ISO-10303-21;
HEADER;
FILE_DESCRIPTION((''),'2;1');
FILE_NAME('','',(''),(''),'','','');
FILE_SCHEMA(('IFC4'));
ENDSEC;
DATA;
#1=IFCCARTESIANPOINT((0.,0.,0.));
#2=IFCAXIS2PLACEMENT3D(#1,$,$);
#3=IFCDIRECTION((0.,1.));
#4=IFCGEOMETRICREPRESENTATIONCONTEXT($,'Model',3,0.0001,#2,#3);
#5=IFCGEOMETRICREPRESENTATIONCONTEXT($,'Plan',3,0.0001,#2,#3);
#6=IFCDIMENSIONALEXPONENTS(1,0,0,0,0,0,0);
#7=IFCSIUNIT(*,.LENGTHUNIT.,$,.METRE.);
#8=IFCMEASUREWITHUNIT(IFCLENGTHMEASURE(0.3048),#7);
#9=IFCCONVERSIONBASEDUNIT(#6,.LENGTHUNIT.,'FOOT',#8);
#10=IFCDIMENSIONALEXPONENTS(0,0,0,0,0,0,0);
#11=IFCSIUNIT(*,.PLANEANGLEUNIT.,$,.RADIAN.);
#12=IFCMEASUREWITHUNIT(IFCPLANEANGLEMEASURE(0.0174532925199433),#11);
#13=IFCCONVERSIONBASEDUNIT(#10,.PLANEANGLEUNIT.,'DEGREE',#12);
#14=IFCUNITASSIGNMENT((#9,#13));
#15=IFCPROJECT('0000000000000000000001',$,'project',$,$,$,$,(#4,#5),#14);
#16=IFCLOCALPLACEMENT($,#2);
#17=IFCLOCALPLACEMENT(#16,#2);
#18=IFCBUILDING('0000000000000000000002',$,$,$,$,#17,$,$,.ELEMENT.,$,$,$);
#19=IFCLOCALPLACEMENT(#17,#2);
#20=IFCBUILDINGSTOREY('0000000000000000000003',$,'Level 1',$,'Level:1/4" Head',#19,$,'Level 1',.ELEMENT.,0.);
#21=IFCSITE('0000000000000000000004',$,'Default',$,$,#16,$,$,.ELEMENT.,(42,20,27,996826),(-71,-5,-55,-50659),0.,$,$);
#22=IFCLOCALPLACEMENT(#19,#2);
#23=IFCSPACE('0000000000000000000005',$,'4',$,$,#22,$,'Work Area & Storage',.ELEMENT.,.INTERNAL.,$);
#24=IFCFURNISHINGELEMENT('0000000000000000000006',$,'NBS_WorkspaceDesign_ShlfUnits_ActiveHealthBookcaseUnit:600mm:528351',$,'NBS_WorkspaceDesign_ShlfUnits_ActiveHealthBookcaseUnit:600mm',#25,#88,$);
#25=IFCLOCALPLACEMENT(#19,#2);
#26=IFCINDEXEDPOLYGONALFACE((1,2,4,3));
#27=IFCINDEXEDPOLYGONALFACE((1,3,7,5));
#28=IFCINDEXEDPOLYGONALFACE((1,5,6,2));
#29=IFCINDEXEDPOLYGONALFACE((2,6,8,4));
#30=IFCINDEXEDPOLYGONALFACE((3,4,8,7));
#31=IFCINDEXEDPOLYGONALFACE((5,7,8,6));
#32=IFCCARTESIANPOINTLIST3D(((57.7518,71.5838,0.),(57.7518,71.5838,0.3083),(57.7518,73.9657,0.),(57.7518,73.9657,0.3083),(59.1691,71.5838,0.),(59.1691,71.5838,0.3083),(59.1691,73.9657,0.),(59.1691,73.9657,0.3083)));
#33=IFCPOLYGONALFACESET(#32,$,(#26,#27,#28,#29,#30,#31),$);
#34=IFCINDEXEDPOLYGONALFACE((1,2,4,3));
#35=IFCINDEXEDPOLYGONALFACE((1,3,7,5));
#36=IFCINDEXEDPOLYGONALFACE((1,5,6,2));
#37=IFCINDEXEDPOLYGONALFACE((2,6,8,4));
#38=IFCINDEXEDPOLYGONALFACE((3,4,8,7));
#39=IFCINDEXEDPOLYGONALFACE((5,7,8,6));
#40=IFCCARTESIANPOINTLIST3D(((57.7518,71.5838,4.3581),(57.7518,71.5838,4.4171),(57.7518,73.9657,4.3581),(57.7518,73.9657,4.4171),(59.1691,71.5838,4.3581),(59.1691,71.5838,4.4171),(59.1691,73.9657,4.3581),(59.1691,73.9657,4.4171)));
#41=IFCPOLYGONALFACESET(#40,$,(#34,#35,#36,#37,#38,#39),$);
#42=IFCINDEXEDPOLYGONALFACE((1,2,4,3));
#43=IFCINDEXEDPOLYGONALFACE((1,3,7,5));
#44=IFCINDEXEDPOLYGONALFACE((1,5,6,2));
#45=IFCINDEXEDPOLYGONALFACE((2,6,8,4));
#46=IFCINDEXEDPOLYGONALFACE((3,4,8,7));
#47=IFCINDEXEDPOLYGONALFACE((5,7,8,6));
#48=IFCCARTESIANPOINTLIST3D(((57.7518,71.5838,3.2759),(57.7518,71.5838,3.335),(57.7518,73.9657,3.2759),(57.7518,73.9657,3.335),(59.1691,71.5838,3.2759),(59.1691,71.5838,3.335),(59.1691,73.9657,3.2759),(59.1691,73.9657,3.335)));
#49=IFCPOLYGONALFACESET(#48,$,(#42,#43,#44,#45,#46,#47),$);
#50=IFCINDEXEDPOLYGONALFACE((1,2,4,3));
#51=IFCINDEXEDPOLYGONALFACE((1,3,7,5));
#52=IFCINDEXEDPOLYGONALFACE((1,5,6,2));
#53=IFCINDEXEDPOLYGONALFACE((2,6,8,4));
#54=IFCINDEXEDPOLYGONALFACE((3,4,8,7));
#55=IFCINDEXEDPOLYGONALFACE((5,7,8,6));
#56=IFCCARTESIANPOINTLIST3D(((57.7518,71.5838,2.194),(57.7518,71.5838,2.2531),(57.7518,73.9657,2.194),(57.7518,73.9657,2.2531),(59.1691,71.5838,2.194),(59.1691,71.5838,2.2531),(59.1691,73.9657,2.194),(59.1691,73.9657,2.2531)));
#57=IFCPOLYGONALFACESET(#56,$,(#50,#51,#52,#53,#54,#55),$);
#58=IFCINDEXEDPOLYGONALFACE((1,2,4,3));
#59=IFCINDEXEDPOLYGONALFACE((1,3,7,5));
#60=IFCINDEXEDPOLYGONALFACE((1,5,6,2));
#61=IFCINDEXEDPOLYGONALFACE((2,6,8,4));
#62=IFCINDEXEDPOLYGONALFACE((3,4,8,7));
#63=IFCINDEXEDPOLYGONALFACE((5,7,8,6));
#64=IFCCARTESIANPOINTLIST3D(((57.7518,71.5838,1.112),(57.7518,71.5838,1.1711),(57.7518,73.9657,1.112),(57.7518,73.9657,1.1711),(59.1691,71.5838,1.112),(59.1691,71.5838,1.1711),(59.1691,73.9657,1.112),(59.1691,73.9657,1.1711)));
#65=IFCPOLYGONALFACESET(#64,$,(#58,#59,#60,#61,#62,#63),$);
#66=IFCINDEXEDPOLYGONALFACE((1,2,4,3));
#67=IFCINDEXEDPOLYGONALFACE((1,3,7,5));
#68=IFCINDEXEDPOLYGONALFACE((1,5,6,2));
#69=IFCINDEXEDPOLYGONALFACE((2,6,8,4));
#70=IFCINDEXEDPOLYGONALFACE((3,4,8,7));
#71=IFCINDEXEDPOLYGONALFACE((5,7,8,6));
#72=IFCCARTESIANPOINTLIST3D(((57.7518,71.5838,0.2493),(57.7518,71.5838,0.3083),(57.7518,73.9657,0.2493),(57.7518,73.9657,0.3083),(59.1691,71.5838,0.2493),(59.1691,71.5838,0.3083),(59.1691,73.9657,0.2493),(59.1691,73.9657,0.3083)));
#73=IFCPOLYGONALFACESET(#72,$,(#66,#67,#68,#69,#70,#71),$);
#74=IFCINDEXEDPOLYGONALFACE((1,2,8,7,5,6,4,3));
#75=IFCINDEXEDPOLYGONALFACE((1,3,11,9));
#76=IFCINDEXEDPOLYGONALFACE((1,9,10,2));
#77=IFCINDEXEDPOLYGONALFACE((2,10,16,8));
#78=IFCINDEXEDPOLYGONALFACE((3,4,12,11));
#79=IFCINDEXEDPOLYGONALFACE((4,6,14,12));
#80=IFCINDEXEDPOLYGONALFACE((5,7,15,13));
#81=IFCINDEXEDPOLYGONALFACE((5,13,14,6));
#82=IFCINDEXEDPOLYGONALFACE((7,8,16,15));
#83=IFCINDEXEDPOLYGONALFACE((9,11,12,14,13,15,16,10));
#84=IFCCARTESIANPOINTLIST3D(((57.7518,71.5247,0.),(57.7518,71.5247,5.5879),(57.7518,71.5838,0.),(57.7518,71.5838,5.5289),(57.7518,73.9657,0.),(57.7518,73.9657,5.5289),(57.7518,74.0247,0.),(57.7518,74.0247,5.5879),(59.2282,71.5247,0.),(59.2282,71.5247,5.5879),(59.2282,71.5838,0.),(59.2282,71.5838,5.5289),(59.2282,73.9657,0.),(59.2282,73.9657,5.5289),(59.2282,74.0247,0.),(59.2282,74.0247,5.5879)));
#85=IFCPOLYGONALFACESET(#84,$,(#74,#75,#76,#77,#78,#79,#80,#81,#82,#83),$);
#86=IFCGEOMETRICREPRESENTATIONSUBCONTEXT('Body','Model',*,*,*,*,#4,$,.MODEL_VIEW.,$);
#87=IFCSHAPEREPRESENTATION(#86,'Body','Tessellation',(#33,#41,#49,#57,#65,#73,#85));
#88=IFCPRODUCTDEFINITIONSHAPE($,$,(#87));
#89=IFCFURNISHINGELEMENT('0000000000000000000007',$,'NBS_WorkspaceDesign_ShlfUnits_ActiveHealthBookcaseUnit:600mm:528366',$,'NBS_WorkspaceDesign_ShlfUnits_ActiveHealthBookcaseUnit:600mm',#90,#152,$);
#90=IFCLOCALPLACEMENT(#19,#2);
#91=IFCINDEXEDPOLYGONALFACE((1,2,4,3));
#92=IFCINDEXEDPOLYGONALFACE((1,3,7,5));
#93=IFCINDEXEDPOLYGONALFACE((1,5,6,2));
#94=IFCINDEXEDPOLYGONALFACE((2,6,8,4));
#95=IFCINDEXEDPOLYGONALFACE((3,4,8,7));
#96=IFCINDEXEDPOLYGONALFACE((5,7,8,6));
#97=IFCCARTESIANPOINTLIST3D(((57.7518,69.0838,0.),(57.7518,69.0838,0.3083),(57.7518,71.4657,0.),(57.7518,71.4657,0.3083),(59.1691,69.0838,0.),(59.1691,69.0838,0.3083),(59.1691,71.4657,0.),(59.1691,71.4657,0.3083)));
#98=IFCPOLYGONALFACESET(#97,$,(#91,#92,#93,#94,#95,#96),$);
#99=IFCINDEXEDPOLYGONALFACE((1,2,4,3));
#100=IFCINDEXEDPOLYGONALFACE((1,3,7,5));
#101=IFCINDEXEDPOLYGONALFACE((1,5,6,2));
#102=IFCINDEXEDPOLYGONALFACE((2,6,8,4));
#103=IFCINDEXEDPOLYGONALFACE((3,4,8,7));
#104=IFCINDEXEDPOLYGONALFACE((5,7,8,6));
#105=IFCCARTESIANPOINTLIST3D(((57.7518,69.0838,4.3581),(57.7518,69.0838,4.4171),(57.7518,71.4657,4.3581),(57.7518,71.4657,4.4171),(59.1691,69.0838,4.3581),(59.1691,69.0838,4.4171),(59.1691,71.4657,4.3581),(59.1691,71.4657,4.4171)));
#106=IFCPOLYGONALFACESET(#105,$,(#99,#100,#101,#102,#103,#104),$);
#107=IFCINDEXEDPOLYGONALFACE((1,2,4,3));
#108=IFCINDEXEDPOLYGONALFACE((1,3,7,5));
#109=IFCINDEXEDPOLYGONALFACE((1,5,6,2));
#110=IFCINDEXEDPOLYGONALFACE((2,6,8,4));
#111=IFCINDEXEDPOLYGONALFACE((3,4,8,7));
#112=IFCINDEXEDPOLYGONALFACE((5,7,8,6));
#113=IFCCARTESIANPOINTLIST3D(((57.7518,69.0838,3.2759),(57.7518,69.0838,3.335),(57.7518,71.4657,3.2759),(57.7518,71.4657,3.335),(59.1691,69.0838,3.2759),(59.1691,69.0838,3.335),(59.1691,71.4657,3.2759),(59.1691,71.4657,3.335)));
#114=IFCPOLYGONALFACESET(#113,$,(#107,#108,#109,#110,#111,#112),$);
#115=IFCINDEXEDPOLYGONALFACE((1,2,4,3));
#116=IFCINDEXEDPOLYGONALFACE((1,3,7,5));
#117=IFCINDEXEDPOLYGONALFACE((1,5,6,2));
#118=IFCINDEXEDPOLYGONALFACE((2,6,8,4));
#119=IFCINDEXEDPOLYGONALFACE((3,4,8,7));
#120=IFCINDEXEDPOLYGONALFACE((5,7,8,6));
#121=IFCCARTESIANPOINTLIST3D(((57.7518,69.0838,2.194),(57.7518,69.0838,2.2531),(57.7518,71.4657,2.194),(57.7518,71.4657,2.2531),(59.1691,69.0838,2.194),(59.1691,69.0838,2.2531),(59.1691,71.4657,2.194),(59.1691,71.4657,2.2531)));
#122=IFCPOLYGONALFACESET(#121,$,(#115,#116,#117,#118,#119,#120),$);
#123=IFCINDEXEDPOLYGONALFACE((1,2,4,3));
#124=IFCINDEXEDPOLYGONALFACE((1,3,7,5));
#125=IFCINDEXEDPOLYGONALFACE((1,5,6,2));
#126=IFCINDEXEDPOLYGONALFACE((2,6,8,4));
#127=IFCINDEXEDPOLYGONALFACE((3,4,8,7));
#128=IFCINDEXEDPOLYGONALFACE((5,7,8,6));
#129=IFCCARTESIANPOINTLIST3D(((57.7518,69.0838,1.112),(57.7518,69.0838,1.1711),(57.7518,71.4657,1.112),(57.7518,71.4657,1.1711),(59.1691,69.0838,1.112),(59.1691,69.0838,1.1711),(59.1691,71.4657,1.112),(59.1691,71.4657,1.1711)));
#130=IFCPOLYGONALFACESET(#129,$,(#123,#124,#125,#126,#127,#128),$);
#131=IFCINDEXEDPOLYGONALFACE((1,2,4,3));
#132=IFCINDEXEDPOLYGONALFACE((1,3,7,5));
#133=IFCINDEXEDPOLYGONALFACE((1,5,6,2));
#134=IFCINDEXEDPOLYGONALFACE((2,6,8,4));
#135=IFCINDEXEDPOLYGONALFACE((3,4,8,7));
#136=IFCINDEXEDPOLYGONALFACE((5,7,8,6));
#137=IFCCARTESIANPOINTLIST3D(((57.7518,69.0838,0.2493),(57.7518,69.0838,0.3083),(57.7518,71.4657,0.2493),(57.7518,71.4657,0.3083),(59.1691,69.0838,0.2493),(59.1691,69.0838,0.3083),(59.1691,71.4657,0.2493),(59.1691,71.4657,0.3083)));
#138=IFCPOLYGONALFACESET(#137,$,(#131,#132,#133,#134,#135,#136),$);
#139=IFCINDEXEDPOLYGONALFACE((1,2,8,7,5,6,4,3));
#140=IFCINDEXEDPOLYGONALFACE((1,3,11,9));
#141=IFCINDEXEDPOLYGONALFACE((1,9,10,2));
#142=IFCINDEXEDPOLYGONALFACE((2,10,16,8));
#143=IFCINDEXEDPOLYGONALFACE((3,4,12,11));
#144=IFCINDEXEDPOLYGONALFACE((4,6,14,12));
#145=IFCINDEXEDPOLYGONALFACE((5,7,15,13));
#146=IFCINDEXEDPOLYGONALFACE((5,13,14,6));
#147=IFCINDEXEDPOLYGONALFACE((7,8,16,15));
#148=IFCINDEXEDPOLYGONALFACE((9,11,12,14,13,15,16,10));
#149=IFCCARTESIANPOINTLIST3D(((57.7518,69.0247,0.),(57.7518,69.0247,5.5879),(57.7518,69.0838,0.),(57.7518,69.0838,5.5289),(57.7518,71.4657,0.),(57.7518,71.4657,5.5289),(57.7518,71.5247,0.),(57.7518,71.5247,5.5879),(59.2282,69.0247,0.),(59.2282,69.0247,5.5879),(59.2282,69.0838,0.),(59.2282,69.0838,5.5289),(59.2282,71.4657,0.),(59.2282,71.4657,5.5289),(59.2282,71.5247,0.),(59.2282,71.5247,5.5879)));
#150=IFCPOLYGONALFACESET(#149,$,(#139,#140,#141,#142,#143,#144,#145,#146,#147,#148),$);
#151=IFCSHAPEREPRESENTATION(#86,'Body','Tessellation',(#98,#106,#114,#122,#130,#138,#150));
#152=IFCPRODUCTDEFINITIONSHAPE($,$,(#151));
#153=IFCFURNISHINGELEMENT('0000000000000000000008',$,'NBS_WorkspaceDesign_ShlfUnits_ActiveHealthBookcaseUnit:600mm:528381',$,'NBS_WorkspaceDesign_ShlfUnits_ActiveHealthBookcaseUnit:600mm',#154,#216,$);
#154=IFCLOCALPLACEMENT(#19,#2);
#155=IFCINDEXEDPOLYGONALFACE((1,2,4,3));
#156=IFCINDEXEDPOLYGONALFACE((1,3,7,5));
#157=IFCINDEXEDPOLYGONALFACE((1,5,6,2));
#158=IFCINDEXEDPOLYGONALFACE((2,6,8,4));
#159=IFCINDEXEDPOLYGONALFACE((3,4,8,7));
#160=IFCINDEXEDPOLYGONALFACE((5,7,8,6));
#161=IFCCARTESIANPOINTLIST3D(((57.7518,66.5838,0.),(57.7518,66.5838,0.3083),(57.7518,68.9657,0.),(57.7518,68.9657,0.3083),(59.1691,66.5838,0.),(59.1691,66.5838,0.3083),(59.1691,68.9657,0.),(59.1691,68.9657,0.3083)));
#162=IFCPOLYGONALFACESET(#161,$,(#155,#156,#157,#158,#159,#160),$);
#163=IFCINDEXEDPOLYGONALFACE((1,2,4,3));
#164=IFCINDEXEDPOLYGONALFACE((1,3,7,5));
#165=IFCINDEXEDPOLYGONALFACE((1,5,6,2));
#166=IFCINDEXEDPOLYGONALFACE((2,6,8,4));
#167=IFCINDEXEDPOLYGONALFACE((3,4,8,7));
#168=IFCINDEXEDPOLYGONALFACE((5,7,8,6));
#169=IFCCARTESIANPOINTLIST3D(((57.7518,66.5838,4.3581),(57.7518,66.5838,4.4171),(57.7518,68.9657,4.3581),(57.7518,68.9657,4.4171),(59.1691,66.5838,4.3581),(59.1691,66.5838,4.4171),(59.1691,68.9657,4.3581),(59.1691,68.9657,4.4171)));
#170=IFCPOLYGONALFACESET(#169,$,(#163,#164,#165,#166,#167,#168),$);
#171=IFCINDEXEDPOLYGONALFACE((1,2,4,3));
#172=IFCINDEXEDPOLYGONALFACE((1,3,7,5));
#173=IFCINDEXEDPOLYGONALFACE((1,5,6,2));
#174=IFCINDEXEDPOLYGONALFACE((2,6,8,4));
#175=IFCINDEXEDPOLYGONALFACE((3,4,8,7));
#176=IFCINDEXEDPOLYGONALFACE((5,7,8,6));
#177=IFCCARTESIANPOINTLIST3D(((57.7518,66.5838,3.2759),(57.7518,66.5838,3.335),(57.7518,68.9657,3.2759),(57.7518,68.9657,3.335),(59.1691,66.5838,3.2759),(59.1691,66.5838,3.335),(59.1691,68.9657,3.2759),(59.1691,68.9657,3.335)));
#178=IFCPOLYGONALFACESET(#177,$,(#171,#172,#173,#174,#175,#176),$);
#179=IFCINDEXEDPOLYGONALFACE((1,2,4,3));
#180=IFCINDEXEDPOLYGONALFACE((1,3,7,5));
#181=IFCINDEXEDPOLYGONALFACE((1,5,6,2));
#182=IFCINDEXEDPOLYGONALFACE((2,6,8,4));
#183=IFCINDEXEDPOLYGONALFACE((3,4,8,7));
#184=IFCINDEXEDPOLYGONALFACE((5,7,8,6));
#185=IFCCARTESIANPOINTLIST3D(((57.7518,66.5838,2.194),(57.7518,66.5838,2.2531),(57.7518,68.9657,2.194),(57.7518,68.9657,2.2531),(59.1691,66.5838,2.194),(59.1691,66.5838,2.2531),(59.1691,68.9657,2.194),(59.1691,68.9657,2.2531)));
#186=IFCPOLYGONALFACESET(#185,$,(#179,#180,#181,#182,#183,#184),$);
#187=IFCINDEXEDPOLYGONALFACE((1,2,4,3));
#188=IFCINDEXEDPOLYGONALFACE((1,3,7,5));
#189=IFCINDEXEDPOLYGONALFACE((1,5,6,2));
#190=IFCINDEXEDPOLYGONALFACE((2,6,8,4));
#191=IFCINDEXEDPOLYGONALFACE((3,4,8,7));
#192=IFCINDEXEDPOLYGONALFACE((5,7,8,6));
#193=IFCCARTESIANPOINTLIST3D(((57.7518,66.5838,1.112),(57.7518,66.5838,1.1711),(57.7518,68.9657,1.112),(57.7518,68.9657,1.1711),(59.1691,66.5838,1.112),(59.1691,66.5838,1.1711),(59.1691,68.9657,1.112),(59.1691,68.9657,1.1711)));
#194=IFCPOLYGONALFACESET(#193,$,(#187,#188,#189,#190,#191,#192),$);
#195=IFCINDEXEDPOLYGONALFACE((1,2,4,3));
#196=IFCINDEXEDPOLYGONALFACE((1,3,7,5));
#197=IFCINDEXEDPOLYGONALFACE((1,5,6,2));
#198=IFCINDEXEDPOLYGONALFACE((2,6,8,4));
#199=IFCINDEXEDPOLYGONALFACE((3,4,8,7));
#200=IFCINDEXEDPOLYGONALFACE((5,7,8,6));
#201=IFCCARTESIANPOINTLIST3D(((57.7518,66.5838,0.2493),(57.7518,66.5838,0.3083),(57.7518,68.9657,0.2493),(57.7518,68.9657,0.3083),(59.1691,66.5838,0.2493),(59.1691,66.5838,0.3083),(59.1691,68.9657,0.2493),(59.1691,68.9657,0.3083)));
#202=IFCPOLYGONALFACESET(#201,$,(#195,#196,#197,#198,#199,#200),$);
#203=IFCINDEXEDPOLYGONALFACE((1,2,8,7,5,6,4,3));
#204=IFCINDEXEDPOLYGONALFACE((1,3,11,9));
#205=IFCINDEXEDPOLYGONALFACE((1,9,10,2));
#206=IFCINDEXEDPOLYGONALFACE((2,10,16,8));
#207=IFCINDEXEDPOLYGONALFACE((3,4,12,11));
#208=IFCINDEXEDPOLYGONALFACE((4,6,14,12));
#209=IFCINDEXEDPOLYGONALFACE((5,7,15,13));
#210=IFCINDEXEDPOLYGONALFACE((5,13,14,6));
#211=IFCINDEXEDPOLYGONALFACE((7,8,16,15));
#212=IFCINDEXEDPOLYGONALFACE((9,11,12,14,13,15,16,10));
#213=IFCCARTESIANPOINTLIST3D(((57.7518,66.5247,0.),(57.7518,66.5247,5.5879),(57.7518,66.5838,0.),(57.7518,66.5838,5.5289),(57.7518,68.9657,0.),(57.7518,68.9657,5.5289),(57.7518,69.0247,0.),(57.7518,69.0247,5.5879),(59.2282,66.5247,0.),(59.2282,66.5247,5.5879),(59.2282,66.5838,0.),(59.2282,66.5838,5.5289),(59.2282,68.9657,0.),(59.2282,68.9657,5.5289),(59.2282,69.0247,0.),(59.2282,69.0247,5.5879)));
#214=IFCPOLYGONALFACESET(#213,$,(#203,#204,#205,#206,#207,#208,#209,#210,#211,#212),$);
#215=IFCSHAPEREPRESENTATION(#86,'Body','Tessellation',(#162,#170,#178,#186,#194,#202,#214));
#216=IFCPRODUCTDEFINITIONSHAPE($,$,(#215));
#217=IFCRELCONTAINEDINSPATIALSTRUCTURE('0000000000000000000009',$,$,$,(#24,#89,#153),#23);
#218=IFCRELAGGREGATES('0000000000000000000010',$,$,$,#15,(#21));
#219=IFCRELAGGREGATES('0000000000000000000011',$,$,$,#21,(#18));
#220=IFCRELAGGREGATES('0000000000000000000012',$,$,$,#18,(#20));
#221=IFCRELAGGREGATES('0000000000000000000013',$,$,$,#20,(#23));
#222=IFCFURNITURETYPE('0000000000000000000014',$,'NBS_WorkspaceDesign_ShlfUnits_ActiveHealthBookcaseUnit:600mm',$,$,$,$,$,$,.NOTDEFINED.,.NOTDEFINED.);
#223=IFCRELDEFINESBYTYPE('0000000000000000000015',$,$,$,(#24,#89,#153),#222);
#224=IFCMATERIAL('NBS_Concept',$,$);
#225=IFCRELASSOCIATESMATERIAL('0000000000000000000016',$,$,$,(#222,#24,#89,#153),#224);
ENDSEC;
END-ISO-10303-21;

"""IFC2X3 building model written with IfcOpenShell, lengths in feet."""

from ifc_helpers import new_model, entity, si_unit, converted_unit, direction, frame, frame_2d, origin, place, context, subcontext, project, spatial, polyline, rectangle, outline, extrude, source, transform, mapped, material, type_object, type_shapes, element, save


model = new_model("IFC2X3")

# Units and contexts
model_context = context("Model", 3, precision=0.0001, world=origin(), true_north=direction((0.0, 1.0)))
plan_context = context("Plan", 3, precision=0.0001, world=origin(), true_north=direction((0.0, 1.0)))
body_context = subcontext(model_context, "Body", "Model", "MODEL_VIEW")
ifc_project = project(units=[converted_unit("LENGTHUNIT", "FOOT", entity("IfcLengthMeasure", 0.3048), si_unit("LENGTHUNIT", "METRE"), dimensions=[1, 0, 0, 0, 0, 0, 0]), converted_unit("PLANEANGLEUNIT", "DEGREE", entity("IfcPlaneAngleMeasure", 0.0174532925199433), si_unit("PLANEANGLEUNIT", "RADIAN"), dimensions=[0, 0, 0, 0, 0, 0, 0])], contexts=[model_context, plan_context])

# Site, building, storey
site_placement = place(None, origin())
site = spatial("IfcSite", under=ifc_project, at=site_placement, Name="Default", CompositionType="ELEMENT", RefLatitude=(42, 20, 27, 996826), RefLongitude=(-71, -5, -55, -50659), RefElevation=0.0)
building_placement = place(site_placement, origin())
building = spatial("IfcBuilding", under=site, at=building_placement, CompositionType="ELEMENT")
storey_placement = place(building_placement, origin())
storey = spatial("IfcBuildingStorey", under=building, at=storey_placement, Name="Level 1", ObjectType="Level:1/4\" Head", LongName="Level 1", CompositionType="ELEMENT", Elevation=0.0)

# Shared definitions
space_1_placement = place(storey_placement, origin())
space_1 = spatial("IfcSpace", under=storey, at=space_1_placement, Name="4", LongName="Work Area & Storage", CompositionType="ELEMENT", InteriorOrExteriorSpace="INTERNAL")

# Furnishing elements
ifc_material_1 = material(Name="NBS_Concept")
furniture_type_1 = type_object("IfcFurnitureType", Name="NBS_WorkspaceDesign_ShlfUnits_ActiveHealthBookcaseUnit:600mm", AssemblyPlace="NOTDEFINED", material=ifc_material_1)
shared_shape_1 = source(origin(), body_context, "Body", "SweptSolid", [
    extrude(rectangle(XDim=1.4173, YDim=2.3819, at=frame_2d((0.0, 0.0), x_axis=(1.0, 0.0))), frame((0.0, -0.7677, 0.0), z_axis=(0.0, 0.0, 1.0), x_axis=(0.0, 1.0, 0.0)), (0.0, 0.0, 1.0), 0.3083),
    extrude(rectangle(XDim=1.4173, YDim=2.3819, at=frame_2d((0.0, 0.0), x_axis=(1.0, 0.0))), frame((0.0, -0.7677, 4.3581), z_axis=(0.0, 0.0, 1.0), x_axis=(0.0, 1.0, 0.0)), (0.0, 0.0, 1.0), 0.0591),
    extrude(rectangle(XDim=1.4173, YDim=2.3819, at=frame_2d((0.0, 0.0), x_axis=(1.0, 0.0))), frame((0.0, -0.7677, 3.2759), z_axis=(0.0, 0.0, 1.0), x_axis=(0.0, 1.0, 0.0)), (0.0, 0.0, 1.0), 0.0591),
    extrude(rectangle(XDim=1.4173, YDim=2.3819, at=frame_2d((0.0, 0.0), x_axis=(1.0, 0.0))), frame((0.0, -0.7677, 2.194), z_axis=(0.0, 0.0, 1.0), x_axis=(0.0, 1.0, 0.0)), (0.0, 0.0, 1.0), 0.0591),
    extrude(rectangle(XDim=1.4173, YDim=2.3819, at=frame_2d((0.0, 0.0), x_axis=(1.0, 0.0))), frame((0.0, -0.7677, 1.112), z_axis=(0.0, 0.0, 1.0), x_axis=(0.0, 1.0, 0.0)), (0.0, 0.0, 1.0), 0.0591),
    extrude(rectangle(XDim=1.4173, YDim=2.3819, at=frame_2d((0.0, 0.0), x_axis=(1.0, 0.0))), frame((0.0, -0.7677, 0.2493), z_axis=(0.0, 0.0, 1.0), x_axis=(0.0, 1.0, 0.0)), (0.0, 0.0, 1.0), 0.0591),
    extrude(outline(polyline([(-2.8087, -1.25), (2.7792, -1.25), (2.7792, -1.1909), (-2.7497, -1.1909), (-2.7497, 1.1909), (2.7792, 1.1909), (2.7792, 1.25), (-2.8087, 1.25), (-2.8087, -1.25)])), frame((0.0, -1.4764, 2.7792), z_axis=(0.0, 1.0, 0.0), x_axis=(0.0, 0.0, -1.0)), (0.0, 0.0, 1.0), 1.4764),
])
type_shapes(furniture_type_1, [shared_shape_1])
for number, where, z_axis, x_axis, name in (
    (1, (59.2282, 72.7747, 0.0), (0.0, 0.0, 1.0), (0.0, -1.0, 0.0), "NBS_WorkspaceDesign_ShlfUnits_ActiveHealthBookcaseUnit:600mm:528351"),
    (2, (59.2282, 70.2747, 0.0), (0.0, 0.0, 1.0), (0.0, -1.0, 0.0), "NBS_WorkspaceDesign_ShlfUnits_ActiveHealthBookcaseUnit:600mm:528366"),
    (3, (59.2282, 67.7747, 0.0), (0.0, 0.0, 1.0), (0.0, -1.0, 0.0), "NBS_WorkspaceDesign_ShlfUnits_ActiveHealthBookcaseUnit:600mm:528381"),
):
    element("IfcFurnishingElement", number, at=place(space_1_placement, frame(where, z_axis=z_axis, x_axis=x_axis)), inside=space_1, type_object=furniture_type_1, material=ifc_material_1, Name=name, ObjectType="NBS_WorkspaceDesign_ShlfUnits_ActiveHealthBookcaseUnit:600mm", context=body_context, shape_type="MappedRepresentation", body=[
        mapped(shared_shape_1, transform((0.0, 0.0, 0.0), scale=1.0)),
    ])

save(model, "model.ifc")
